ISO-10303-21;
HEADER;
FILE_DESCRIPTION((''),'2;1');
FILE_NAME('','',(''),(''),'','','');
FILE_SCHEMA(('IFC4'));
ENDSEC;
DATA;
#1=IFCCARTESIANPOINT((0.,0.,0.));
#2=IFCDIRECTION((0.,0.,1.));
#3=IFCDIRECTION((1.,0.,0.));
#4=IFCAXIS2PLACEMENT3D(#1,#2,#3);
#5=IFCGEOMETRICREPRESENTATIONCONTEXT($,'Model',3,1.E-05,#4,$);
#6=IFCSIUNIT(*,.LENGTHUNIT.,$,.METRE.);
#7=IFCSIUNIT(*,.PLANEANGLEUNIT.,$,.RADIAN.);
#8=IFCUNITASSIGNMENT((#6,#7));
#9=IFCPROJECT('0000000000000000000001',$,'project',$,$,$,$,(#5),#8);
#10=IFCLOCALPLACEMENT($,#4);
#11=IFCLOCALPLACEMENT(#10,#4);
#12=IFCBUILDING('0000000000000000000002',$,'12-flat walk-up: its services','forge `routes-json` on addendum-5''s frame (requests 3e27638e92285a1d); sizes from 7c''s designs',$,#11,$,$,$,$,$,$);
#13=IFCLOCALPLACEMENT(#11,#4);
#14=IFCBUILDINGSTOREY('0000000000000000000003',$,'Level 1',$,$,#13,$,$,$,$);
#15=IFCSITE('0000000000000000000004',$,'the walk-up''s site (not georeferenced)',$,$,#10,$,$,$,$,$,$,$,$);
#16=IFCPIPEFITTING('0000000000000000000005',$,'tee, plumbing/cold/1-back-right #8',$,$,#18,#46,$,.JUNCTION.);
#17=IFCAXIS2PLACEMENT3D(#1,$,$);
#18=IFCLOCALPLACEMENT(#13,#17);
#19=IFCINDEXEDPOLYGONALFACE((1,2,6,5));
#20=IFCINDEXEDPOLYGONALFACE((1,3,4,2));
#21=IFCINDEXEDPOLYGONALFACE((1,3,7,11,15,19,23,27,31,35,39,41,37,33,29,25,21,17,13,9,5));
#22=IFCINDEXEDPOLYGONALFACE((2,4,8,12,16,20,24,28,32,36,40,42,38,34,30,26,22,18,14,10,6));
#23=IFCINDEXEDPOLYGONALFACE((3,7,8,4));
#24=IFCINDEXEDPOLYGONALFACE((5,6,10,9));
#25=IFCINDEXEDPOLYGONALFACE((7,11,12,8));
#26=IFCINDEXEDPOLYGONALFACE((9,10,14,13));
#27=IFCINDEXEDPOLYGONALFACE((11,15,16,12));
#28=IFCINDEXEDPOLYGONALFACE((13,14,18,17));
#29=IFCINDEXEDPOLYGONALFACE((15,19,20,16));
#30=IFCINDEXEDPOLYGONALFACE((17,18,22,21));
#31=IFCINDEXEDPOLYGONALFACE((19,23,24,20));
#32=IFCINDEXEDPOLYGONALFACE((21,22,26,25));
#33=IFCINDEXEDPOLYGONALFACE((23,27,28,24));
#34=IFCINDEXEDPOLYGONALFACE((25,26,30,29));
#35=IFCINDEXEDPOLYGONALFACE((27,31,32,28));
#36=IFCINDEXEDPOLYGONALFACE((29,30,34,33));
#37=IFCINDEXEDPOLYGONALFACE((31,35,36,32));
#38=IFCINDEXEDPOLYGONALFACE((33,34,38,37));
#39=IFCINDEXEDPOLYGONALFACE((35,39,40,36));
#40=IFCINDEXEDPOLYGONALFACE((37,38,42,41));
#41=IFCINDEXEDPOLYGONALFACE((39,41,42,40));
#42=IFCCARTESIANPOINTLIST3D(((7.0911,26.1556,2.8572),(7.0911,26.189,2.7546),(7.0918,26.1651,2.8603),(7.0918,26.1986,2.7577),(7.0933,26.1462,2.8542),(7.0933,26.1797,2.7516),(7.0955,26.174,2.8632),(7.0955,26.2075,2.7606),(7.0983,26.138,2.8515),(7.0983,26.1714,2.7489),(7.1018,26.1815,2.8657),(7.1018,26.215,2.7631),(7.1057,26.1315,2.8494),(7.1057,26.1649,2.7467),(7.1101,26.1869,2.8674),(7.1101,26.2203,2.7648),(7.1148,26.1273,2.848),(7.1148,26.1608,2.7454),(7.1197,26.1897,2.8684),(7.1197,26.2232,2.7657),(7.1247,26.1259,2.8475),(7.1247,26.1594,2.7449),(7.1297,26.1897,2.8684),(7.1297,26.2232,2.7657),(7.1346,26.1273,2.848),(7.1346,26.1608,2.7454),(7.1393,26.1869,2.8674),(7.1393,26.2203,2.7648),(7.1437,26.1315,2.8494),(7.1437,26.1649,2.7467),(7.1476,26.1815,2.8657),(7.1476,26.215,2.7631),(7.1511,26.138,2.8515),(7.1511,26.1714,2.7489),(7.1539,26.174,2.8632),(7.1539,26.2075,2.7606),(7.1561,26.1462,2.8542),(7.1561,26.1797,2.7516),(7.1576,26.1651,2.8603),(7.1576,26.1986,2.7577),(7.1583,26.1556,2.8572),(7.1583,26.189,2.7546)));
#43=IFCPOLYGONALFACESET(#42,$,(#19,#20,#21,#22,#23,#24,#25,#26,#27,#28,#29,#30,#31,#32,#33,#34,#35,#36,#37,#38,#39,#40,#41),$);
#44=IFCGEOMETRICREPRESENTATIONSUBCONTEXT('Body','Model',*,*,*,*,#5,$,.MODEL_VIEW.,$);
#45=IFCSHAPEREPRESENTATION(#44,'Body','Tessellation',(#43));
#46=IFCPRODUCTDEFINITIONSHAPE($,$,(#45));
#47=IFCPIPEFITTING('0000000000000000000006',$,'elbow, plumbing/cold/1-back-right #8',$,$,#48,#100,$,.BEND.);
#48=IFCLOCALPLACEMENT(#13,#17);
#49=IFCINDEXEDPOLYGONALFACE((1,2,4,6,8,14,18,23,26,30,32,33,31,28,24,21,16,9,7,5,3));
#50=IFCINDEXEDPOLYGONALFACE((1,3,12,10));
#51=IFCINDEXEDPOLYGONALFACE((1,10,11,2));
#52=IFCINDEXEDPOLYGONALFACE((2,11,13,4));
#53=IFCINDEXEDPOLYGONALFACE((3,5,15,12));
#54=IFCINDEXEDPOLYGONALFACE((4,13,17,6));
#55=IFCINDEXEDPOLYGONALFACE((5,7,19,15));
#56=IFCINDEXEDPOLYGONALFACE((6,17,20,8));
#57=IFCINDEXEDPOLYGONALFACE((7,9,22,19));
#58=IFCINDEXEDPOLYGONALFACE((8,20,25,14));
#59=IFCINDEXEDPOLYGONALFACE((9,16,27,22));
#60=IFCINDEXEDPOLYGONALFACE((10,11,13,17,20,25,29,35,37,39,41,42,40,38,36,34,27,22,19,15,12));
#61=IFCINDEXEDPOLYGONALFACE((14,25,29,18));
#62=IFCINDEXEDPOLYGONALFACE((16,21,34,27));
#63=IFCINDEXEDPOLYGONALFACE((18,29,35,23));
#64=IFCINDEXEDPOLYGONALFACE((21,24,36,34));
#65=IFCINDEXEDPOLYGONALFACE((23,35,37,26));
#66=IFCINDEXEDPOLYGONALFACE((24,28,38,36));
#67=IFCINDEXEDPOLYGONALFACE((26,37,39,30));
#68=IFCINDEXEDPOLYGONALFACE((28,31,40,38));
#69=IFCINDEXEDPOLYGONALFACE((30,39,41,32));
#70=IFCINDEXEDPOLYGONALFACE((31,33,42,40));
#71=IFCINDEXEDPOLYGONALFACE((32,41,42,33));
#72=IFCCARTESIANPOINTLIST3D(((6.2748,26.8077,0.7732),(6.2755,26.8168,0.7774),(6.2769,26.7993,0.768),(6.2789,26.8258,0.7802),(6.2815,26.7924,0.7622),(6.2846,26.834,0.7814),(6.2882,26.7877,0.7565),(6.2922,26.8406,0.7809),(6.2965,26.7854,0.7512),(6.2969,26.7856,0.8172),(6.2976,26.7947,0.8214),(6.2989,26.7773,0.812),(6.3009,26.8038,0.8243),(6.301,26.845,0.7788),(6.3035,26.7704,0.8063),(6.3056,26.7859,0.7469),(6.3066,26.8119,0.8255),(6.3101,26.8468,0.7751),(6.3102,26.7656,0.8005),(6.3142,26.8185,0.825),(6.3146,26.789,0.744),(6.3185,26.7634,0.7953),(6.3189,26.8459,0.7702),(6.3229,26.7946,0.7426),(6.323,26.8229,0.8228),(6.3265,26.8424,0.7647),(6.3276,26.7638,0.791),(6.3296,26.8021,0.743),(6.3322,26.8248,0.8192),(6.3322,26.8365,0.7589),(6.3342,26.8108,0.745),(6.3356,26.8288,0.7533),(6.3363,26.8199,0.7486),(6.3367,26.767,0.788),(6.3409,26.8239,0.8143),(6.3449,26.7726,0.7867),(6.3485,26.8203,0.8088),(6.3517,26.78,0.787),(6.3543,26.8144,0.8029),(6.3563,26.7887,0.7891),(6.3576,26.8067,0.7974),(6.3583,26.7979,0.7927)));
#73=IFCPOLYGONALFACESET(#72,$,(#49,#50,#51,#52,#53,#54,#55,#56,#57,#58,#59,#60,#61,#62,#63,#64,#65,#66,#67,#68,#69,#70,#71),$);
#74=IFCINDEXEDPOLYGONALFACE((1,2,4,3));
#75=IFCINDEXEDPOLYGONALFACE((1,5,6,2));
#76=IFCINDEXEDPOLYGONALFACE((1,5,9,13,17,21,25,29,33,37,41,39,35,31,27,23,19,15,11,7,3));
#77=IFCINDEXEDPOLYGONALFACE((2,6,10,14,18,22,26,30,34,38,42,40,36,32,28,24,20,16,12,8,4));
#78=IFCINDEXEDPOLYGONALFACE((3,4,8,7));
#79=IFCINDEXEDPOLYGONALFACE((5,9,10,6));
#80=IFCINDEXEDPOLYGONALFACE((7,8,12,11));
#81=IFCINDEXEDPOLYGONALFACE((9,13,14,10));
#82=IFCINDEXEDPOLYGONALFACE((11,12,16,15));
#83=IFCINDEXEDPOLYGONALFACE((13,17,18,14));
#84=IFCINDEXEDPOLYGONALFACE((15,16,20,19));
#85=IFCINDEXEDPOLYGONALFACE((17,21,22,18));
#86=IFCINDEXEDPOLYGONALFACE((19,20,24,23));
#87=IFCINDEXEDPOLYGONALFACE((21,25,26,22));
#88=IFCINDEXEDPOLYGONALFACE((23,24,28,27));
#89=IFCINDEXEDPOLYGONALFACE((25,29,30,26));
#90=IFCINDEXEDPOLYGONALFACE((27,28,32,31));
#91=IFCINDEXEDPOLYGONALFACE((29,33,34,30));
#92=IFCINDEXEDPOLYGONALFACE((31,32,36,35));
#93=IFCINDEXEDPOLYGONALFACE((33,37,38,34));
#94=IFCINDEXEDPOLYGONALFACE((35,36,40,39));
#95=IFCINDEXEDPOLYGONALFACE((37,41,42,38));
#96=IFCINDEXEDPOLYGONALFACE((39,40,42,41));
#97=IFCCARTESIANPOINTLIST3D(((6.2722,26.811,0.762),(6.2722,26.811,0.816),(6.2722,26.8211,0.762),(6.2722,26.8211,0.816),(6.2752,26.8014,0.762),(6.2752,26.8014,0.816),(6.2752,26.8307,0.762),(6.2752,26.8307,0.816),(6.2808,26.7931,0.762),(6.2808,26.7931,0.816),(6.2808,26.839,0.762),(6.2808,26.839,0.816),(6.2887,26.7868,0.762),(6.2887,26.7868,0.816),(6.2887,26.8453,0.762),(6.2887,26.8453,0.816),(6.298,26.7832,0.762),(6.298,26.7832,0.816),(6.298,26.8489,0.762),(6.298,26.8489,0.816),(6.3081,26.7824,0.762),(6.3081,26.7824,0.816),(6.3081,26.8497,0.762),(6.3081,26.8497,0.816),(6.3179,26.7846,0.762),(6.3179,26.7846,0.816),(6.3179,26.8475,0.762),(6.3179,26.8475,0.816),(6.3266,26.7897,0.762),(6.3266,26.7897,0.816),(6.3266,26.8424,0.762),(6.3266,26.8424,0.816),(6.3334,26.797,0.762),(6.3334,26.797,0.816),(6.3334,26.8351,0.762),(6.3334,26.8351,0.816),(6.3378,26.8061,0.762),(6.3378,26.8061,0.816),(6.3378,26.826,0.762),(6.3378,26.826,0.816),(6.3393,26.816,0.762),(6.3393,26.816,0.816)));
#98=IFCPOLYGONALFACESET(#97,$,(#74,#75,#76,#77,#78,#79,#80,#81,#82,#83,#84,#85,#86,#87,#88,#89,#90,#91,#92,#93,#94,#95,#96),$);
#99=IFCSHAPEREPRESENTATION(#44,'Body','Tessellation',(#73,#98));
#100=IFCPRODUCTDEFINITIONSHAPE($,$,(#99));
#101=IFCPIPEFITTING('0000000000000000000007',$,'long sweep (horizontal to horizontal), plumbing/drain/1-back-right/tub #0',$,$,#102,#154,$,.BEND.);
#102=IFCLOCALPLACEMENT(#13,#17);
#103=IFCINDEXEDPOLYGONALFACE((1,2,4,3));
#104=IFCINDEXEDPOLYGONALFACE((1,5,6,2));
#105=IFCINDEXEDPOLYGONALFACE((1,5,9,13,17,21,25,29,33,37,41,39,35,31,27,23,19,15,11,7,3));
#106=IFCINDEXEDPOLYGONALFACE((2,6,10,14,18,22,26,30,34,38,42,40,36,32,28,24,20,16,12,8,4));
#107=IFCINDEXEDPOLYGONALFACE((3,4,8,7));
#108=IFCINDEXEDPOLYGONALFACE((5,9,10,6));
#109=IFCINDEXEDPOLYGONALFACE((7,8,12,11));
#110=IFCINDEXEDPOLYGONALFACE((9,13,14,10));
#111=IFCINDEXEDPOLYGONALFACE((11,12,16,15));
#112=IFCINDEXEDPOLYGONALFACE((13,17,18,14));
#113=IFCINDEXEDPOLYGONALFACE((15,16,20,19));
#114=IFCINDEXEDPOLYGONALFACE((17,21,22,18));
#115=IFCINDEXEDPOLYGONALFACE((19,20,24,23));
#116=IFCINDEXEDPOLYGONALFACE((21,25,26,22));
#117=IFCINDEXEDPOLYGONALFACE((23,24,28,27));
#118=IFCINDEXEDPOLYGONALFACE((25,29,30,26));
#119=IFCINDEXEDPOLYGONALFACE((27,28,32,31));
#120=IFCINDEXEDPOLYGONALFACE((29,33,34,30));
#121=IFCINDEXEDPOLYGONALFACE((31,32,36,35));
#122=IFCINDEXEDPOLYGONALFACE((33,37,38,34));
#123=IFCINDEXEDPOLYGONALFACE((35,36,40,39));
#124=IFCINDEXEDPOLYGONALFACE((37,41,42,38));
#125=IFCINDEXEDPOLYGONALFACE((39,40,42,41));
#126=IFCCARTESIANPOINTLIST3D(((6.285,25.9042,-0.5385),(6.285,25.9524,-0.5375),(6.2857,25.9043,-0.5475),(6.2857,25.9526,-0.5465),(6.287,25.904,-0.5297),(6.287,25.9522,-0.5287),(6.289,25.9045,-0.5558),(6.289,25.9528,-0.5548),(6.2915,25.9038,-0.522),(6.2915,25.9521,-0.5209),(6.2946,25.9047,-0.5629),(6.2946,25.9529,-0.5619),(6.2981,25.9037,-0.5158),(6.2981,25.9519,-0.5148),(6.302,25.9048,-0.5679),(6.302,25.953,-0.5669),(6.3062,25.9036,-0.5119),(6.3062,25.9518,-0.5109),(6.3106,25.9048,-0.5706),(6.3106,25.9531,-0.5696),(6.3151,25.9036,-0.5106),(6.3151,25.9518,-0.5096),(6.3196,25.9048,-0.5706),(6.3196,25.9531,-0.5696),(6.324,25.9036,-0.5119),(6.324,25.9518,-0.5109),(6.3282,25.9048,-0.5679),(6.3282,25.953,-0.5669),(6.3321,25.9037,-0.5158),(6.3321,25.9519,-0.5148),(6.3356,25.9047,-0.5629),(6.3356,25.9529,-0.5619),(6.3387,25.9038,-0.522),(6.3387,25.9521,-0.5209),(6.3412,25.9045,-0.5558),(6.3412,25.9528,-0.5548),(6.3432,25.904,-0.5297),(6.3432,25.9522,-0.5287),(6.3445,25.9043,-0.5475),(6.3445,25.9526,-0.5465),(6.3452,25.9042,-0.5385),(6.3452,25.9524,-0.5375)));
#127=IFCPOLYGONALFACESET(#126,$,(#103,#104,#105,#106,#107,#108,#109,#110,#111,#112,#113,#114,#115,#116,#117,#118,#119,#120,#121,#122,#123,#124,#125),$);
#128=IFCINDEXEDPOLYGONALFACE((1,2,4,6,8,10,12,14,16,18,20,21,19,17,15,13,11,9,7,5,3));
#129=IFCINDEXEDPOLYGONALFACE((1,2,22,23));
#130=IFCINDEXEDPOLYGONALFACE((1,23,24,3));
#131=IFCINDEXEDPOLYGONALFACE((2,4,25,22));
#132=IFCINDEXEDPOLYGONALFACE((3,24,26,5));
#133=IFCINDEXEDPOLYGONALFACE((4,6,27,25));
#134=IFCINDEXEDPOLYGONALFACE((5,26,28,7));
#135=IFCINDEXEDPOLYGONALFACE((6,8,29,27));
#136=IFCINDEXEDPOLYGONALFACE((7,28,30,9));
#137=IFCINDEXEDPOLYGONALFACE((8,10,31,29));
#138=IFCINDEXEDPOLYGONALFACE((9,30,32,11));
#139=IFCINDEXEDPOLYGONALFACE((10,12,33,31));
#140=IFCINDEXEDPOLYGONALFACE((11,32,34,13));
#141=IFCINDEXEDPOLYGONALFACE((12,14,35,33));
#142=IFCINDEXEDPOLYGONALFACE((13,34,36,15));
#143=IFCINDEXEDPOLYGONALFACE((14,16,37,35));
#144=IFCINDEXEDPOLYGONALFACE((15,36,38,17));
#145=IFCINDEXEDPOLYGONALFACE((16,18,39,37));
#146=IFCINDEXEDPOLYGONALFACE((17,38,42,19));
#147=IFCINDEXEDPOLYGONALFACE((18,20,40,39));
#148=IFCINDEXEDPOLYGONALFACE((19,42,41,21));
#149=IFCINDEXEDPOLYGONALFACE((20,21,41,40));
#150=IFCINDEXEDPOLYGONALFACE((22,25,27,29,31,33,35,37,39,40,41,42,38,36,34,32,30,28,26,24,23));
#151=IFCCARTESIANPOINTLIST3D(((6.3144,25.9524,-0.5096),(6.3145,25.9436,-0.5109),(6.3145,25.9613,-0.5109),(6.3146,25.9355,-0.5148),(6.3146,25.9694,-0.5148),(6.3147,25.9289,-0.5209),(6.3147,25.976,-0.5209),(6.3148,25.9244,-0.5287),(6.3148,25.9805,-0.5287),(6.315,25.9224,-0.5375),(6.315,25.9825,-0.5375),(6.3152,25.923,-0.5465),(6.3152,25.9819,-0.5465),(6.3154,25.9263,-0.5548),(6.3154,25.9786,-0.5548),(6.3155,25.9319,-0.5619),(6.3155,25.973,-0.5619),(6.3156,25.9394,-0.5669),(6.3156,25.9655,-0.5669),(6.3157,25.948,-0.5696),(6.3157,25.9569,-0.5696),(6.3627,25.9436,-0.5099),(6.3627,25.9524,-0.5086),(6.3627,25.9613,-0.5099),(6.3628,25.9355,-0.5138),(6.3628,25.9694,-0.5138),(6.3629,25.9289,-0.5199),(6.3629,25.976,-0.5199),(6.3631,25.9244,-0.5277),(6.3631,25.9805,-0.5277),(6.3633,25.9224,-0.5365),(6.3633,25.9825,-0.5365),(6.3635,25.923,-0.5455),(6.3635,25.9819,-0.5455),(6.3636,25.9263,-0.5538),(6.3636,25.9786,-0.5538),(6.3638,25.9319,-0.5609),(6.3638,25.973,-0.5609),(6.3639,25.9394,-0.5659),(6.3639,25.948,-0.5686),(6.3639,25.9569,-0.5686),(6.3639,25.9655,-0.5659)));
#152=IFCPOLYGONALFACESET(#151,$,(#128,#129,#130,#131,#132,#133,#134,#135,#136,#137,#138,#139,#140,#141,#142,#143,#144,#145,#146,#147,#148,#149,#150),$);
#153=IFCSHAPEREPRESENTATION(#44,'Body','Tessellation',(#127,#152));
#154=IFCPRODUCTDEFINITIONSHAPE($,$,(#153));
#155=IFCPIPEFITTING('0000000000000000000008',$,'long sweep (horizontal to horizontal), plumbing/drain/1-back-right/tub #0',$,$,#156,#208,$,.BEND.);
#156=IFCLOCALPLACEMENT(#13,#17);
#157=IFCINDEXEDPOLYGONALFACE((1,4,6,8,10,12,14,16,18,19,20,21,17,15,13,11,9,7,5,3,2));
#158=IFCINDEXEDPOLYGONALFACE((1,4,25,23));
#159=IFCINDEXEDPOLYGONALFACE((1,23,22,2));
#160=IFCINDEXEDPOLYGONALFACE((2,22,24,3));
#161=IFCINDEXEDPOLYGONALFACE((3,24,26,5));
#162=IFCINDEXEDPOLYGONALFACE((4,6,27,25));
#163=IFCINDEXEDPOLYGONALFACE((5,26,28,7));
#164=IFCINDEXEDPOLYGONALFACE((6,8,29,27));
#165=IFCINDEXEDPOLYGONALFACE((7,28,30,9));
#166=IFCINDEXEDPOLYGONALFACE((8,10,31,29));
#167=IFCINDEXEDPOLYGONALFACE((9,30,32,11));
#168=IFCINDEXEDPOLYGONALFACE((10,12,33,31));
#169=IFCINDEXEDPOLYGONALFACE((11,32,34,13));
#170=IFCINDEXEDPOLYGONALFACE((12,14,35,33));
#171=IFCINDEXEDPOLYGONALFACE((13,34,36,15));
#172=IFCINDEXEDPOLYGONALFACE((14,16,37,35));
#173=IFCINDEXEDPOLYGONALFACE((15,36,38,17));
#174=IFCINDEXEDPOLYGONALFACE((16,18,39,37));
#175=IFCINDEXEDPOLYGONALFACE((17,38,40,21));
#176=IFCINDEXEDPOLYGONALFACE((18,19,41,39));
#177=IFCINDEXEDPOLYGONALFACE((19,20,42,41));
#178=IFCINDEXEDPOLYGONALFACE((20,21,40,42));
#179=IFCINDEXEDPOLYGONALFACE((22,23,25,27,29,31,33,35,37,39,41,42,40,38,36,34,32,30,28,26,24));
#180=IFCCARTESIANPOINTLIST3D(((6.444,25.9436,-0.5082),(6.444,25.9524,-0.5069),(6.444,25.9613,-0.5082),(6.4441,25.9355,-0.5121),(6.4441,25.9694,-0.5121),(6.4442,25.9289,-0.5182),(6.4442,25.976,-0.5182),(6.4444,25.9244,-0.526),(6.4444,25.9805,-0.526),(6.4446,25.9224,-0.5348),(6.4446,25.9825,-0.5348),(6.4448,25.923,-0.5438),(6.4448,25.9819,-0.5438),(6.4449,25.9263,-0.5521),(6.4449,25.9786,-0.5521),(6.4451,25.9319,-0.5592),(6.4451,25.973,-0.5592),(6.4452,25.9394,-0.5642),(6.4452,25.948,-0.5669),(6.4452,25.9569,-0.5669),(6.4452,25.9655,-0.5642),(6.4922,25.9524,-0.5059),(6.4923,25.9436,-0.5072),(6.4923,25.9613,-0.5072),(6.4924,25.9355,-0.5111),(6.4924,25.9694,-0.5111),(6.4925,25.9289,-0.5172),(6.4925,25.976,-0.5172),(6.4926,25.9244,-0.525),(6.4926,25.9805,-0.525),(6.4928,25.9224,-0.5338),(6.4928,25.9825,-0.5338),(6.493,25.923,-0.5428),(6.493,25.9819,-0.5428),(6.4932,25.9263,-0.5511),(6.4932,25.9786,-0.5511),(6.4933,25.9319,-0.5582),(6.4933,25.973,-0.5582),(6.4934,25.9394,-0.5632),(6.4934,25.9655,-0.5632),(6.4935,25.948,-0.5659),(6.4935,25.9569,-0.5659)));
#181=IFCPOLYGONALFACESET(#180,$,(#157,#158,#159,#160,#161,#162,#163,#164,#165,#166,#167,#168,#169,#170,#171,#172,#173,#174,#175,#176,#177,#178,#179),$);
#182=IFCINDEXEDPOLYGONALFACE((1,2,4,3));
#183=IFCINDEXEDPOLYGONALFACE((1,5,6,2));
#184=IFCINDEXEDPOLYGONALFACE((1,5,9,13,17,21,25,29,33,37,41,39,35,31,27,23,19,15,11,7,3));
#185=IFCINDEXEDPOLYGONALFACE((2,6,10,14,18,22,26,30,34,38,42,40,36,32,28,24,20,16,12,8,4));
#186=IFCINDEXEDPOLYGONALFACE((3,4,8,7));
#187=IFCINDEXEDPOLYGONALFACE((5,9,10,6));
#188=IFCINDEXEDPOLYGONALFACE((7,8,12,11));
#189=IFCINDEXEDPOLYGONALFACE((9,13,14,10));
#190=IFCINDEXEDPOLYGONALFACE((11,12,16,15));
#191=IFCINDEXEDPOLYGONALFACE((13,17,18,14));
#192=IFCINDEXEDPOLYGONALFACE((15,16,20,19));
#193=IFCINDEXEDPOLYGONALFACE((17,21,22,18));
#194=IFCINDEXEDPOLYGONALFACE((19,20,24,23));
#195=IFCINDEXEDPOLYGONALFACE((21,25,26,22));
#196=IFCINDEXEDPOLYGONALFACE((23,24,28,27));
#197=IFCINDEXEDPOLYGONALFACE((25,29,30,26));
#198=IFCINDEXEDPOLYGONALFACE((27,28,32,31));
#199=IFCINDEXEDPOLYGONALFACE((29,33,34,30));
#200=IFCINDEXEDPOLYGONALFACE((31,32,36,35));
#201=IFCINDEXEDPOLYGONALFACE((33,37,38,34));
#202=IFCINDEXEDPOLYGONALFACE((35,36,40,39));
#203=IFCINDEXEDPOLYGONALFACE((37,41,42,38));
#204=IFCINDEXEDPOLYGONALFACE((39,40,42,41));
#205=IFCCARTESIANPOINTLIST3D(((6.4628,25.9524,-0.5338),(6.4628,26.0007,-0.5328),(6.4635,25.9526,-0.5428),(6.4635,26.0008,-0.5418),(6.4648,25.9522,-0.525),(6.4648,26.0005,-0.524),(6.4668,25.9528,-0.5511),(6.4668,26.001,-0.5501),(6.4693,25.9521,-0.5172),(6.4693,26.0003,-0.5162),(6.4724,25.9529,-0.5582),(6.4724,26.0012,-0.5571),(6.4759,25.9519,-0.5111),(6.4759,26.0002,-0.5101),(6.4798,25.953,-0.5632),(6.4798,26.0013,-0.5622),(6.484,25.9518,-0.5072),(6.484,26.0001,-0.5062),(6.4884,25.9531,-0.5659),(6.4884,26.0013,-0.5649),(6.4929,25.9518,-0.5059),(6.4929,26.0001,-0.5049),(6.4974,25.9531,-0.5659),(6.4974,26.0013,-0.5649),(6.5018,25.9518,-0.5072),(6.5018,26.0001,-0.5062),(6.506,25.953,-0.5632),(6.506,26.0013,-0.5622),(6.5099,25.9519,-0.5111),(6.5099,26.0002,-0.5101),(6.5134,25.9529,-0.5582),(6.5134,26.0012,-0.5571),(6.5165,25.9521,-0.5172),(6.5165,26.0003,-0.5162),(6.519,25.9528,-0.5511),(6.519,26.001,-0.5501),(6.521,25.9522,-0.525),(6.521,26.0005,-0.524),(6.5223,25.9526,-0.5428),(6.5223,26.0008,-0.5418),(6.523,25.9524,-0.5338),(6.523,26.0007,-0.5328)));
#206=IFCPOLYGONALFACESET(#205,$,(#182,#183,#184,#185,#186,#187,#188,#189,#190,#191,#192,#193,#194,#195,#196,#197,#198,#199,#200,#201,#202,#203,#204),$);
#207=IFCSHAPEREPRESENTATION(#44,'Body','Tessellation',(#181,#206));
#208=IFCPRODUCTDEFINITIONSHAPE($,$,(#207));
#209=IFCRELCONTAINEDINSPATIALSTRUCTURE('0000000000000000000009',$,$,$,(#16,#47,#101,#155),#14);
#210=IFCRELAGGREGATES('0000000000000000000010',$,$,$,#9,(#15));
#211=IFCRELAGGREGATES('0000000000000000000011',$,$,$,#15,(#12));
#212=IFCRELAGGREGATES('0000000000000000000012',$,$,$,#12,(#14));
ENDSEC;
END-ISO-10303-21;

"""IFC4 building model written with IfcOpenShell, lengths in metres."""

from ifc_helpers import new_model, entity, si_unit, frame, origin_with_axes, place, context, subcontext, project, spatial, element, save


model = new_model("IFC4")

# Units and contexts
model_context = context("Model", 3, precision=1e-05, world=origin_with_axes())
body_context = subcontext(model_context, "Body", "Model", "MODEL_VIEW")
ifc_project = project(units=[si_unit("LENGTHUNIT", "METRE"), si_unit("PLANEANGLEUNIT", "RADIAN")], contexts=[model_context])

# Site, building, storey
site_placement = place(None, origin_with_axes())
site = spatial("IfcSite", under=ifc_project, at=site_placement, Name="the walk-up's site (not georeferenced)")
building_placement = place(site_placement, origin_with_axes())
building = spatial("IfcBuilding", under=site, at=building_placement, Name="12-flat walk-up: its services", Description="forge `routes-json` on addendum-5's frame (requests 3e27638e92285a1d); sizes from 7c's designs")
storey_placement = place(building_placement, origin_with_axes())
storey = spatial("IfcBuildingStorey", under=building, at=storey_placement, Name="Level 1")

# Pipe fittings
pipe_fitting_1_placement = place(storey_placement, frame((7.1247, 26.158, 2.858), z_axis=(0.0, 0.0, 1.0), x_axis=(1.0, 0.0, 0.0)))
element("IfcPipeFitting", 1, at=pipe_fitting_1_placement, inside=storey, Name="tee, plumbing/cold/1-back-right #8", PredefinedType="JUNCTION", context=body_context, shape_type="AdvancedSweptSolid", body=[
    entity("IfcSweptDiskSolid", entity("IfcPolyline", [entity("IfcCartesianPoint", [0.0, 0.0, 0.0]), entity("IfcCartesianPoint", [0.0, 0.0335, -0.1026])]), 0.0337),
])
pipe_fitting_2_placement = place(storey_placement, frame((6.3276, 26.794, 0.8061), z_axis=(0.0, 0.0, 1.0), x_axis=(1.0, 0.0, 0.0)))
element("IfcPipeFitting", 2, at=pipe_fitting_2_placement, inside=storey, Name="elbow, plumbing/cold/1-back-right #8", PredefinedType="BEND", context=body_context, shape_type="AdvancedSweptSolid", body=[
    entity("IfcSweptDiskSolid", entity("IfcPolyline", [entity("IfcCartesianPoint", [0.0, 0.0, 0.0]), entity("IfcCartesianPoint", [-0.022, 0.022, -0.0441])]), 0.0337),
    entity("IfcSweptDiskSolid", entity("IfcPolyline", [entity("IfcCartesianPoint", [-0.022, 0.022, -0.0441]), entity("IfcCartesianPoint", [-0.022, 0.022, 0.0099])]), 0.0337),
])
pipe_fitting_3_placement = place(storey_placement, frame((6.3151, 25.9042, -0.5408), z_axis=(0.0, 0.0, 1.0), x_axis=(1.0, 0.0, 0.0)))
element("IfcPipeFitting", 3, at=pipe_fitting_3_placement, inside=storey, Name="long sweep (horizontal to horizontal), plumbing/drain/1-back-right/tub #0", PredefinedType="BEND", context=body_context, shape_type="AdvancedSweptSolid", body=[
    entity("IfcSweptDiskSolid", entity("IfcPolyline", [entity("IfcCartesianPoint", [0.0, 0.0, 0.0]), entity("IfcCartesianPoint", [0.0, 0.0482, 0.001])]), 0.0302),
    entity("IfcSweptDiskSolid", entity("IfcPolyline", [entity("IfcCartesianPoint", [0.0, 0.0482, 0.001]), entity("IfcCartesianPoint", [0.0482, 0.0482, 0.002])]), 0.0302),
])
pipe_fitting_4_placement = place(storey_placement, frame((6.4446, 25.9524, -0.5371), z_axis=(0.0, 0.0, 1.0), x_axis=(1.0, 0.0, 0.0)))
element("IfcPipeFitting", 4, at=pipe_fitting_4_placement, inside=storey, Name="long sweep (horizontal to horizontal), plumbing/drain/1-back-right/tub #0", PredefinedType="BEND", context=body_context, shape_type="AdvancedSweptSolid", body=[
    entity("IfcSweptDiskSolid", entity("IfcPolyline", [entity("IfcCartesianPoint", [0.0, 0.0, 0.0]), entity("IfcCartesianPoint", [0.0482, 0.0, 0.001])]), 0.0302),
    entity("IfcSweptDiskSolid", entity("IfcPolyline", [entity("IfcCartesianPoint", [0.0482, 0.0, 0.001]), entity("IfcCartesianPoint", [0.0482, 0.0482, 0.002])]), 0.0302),
])

save(model, "model.ifc")
